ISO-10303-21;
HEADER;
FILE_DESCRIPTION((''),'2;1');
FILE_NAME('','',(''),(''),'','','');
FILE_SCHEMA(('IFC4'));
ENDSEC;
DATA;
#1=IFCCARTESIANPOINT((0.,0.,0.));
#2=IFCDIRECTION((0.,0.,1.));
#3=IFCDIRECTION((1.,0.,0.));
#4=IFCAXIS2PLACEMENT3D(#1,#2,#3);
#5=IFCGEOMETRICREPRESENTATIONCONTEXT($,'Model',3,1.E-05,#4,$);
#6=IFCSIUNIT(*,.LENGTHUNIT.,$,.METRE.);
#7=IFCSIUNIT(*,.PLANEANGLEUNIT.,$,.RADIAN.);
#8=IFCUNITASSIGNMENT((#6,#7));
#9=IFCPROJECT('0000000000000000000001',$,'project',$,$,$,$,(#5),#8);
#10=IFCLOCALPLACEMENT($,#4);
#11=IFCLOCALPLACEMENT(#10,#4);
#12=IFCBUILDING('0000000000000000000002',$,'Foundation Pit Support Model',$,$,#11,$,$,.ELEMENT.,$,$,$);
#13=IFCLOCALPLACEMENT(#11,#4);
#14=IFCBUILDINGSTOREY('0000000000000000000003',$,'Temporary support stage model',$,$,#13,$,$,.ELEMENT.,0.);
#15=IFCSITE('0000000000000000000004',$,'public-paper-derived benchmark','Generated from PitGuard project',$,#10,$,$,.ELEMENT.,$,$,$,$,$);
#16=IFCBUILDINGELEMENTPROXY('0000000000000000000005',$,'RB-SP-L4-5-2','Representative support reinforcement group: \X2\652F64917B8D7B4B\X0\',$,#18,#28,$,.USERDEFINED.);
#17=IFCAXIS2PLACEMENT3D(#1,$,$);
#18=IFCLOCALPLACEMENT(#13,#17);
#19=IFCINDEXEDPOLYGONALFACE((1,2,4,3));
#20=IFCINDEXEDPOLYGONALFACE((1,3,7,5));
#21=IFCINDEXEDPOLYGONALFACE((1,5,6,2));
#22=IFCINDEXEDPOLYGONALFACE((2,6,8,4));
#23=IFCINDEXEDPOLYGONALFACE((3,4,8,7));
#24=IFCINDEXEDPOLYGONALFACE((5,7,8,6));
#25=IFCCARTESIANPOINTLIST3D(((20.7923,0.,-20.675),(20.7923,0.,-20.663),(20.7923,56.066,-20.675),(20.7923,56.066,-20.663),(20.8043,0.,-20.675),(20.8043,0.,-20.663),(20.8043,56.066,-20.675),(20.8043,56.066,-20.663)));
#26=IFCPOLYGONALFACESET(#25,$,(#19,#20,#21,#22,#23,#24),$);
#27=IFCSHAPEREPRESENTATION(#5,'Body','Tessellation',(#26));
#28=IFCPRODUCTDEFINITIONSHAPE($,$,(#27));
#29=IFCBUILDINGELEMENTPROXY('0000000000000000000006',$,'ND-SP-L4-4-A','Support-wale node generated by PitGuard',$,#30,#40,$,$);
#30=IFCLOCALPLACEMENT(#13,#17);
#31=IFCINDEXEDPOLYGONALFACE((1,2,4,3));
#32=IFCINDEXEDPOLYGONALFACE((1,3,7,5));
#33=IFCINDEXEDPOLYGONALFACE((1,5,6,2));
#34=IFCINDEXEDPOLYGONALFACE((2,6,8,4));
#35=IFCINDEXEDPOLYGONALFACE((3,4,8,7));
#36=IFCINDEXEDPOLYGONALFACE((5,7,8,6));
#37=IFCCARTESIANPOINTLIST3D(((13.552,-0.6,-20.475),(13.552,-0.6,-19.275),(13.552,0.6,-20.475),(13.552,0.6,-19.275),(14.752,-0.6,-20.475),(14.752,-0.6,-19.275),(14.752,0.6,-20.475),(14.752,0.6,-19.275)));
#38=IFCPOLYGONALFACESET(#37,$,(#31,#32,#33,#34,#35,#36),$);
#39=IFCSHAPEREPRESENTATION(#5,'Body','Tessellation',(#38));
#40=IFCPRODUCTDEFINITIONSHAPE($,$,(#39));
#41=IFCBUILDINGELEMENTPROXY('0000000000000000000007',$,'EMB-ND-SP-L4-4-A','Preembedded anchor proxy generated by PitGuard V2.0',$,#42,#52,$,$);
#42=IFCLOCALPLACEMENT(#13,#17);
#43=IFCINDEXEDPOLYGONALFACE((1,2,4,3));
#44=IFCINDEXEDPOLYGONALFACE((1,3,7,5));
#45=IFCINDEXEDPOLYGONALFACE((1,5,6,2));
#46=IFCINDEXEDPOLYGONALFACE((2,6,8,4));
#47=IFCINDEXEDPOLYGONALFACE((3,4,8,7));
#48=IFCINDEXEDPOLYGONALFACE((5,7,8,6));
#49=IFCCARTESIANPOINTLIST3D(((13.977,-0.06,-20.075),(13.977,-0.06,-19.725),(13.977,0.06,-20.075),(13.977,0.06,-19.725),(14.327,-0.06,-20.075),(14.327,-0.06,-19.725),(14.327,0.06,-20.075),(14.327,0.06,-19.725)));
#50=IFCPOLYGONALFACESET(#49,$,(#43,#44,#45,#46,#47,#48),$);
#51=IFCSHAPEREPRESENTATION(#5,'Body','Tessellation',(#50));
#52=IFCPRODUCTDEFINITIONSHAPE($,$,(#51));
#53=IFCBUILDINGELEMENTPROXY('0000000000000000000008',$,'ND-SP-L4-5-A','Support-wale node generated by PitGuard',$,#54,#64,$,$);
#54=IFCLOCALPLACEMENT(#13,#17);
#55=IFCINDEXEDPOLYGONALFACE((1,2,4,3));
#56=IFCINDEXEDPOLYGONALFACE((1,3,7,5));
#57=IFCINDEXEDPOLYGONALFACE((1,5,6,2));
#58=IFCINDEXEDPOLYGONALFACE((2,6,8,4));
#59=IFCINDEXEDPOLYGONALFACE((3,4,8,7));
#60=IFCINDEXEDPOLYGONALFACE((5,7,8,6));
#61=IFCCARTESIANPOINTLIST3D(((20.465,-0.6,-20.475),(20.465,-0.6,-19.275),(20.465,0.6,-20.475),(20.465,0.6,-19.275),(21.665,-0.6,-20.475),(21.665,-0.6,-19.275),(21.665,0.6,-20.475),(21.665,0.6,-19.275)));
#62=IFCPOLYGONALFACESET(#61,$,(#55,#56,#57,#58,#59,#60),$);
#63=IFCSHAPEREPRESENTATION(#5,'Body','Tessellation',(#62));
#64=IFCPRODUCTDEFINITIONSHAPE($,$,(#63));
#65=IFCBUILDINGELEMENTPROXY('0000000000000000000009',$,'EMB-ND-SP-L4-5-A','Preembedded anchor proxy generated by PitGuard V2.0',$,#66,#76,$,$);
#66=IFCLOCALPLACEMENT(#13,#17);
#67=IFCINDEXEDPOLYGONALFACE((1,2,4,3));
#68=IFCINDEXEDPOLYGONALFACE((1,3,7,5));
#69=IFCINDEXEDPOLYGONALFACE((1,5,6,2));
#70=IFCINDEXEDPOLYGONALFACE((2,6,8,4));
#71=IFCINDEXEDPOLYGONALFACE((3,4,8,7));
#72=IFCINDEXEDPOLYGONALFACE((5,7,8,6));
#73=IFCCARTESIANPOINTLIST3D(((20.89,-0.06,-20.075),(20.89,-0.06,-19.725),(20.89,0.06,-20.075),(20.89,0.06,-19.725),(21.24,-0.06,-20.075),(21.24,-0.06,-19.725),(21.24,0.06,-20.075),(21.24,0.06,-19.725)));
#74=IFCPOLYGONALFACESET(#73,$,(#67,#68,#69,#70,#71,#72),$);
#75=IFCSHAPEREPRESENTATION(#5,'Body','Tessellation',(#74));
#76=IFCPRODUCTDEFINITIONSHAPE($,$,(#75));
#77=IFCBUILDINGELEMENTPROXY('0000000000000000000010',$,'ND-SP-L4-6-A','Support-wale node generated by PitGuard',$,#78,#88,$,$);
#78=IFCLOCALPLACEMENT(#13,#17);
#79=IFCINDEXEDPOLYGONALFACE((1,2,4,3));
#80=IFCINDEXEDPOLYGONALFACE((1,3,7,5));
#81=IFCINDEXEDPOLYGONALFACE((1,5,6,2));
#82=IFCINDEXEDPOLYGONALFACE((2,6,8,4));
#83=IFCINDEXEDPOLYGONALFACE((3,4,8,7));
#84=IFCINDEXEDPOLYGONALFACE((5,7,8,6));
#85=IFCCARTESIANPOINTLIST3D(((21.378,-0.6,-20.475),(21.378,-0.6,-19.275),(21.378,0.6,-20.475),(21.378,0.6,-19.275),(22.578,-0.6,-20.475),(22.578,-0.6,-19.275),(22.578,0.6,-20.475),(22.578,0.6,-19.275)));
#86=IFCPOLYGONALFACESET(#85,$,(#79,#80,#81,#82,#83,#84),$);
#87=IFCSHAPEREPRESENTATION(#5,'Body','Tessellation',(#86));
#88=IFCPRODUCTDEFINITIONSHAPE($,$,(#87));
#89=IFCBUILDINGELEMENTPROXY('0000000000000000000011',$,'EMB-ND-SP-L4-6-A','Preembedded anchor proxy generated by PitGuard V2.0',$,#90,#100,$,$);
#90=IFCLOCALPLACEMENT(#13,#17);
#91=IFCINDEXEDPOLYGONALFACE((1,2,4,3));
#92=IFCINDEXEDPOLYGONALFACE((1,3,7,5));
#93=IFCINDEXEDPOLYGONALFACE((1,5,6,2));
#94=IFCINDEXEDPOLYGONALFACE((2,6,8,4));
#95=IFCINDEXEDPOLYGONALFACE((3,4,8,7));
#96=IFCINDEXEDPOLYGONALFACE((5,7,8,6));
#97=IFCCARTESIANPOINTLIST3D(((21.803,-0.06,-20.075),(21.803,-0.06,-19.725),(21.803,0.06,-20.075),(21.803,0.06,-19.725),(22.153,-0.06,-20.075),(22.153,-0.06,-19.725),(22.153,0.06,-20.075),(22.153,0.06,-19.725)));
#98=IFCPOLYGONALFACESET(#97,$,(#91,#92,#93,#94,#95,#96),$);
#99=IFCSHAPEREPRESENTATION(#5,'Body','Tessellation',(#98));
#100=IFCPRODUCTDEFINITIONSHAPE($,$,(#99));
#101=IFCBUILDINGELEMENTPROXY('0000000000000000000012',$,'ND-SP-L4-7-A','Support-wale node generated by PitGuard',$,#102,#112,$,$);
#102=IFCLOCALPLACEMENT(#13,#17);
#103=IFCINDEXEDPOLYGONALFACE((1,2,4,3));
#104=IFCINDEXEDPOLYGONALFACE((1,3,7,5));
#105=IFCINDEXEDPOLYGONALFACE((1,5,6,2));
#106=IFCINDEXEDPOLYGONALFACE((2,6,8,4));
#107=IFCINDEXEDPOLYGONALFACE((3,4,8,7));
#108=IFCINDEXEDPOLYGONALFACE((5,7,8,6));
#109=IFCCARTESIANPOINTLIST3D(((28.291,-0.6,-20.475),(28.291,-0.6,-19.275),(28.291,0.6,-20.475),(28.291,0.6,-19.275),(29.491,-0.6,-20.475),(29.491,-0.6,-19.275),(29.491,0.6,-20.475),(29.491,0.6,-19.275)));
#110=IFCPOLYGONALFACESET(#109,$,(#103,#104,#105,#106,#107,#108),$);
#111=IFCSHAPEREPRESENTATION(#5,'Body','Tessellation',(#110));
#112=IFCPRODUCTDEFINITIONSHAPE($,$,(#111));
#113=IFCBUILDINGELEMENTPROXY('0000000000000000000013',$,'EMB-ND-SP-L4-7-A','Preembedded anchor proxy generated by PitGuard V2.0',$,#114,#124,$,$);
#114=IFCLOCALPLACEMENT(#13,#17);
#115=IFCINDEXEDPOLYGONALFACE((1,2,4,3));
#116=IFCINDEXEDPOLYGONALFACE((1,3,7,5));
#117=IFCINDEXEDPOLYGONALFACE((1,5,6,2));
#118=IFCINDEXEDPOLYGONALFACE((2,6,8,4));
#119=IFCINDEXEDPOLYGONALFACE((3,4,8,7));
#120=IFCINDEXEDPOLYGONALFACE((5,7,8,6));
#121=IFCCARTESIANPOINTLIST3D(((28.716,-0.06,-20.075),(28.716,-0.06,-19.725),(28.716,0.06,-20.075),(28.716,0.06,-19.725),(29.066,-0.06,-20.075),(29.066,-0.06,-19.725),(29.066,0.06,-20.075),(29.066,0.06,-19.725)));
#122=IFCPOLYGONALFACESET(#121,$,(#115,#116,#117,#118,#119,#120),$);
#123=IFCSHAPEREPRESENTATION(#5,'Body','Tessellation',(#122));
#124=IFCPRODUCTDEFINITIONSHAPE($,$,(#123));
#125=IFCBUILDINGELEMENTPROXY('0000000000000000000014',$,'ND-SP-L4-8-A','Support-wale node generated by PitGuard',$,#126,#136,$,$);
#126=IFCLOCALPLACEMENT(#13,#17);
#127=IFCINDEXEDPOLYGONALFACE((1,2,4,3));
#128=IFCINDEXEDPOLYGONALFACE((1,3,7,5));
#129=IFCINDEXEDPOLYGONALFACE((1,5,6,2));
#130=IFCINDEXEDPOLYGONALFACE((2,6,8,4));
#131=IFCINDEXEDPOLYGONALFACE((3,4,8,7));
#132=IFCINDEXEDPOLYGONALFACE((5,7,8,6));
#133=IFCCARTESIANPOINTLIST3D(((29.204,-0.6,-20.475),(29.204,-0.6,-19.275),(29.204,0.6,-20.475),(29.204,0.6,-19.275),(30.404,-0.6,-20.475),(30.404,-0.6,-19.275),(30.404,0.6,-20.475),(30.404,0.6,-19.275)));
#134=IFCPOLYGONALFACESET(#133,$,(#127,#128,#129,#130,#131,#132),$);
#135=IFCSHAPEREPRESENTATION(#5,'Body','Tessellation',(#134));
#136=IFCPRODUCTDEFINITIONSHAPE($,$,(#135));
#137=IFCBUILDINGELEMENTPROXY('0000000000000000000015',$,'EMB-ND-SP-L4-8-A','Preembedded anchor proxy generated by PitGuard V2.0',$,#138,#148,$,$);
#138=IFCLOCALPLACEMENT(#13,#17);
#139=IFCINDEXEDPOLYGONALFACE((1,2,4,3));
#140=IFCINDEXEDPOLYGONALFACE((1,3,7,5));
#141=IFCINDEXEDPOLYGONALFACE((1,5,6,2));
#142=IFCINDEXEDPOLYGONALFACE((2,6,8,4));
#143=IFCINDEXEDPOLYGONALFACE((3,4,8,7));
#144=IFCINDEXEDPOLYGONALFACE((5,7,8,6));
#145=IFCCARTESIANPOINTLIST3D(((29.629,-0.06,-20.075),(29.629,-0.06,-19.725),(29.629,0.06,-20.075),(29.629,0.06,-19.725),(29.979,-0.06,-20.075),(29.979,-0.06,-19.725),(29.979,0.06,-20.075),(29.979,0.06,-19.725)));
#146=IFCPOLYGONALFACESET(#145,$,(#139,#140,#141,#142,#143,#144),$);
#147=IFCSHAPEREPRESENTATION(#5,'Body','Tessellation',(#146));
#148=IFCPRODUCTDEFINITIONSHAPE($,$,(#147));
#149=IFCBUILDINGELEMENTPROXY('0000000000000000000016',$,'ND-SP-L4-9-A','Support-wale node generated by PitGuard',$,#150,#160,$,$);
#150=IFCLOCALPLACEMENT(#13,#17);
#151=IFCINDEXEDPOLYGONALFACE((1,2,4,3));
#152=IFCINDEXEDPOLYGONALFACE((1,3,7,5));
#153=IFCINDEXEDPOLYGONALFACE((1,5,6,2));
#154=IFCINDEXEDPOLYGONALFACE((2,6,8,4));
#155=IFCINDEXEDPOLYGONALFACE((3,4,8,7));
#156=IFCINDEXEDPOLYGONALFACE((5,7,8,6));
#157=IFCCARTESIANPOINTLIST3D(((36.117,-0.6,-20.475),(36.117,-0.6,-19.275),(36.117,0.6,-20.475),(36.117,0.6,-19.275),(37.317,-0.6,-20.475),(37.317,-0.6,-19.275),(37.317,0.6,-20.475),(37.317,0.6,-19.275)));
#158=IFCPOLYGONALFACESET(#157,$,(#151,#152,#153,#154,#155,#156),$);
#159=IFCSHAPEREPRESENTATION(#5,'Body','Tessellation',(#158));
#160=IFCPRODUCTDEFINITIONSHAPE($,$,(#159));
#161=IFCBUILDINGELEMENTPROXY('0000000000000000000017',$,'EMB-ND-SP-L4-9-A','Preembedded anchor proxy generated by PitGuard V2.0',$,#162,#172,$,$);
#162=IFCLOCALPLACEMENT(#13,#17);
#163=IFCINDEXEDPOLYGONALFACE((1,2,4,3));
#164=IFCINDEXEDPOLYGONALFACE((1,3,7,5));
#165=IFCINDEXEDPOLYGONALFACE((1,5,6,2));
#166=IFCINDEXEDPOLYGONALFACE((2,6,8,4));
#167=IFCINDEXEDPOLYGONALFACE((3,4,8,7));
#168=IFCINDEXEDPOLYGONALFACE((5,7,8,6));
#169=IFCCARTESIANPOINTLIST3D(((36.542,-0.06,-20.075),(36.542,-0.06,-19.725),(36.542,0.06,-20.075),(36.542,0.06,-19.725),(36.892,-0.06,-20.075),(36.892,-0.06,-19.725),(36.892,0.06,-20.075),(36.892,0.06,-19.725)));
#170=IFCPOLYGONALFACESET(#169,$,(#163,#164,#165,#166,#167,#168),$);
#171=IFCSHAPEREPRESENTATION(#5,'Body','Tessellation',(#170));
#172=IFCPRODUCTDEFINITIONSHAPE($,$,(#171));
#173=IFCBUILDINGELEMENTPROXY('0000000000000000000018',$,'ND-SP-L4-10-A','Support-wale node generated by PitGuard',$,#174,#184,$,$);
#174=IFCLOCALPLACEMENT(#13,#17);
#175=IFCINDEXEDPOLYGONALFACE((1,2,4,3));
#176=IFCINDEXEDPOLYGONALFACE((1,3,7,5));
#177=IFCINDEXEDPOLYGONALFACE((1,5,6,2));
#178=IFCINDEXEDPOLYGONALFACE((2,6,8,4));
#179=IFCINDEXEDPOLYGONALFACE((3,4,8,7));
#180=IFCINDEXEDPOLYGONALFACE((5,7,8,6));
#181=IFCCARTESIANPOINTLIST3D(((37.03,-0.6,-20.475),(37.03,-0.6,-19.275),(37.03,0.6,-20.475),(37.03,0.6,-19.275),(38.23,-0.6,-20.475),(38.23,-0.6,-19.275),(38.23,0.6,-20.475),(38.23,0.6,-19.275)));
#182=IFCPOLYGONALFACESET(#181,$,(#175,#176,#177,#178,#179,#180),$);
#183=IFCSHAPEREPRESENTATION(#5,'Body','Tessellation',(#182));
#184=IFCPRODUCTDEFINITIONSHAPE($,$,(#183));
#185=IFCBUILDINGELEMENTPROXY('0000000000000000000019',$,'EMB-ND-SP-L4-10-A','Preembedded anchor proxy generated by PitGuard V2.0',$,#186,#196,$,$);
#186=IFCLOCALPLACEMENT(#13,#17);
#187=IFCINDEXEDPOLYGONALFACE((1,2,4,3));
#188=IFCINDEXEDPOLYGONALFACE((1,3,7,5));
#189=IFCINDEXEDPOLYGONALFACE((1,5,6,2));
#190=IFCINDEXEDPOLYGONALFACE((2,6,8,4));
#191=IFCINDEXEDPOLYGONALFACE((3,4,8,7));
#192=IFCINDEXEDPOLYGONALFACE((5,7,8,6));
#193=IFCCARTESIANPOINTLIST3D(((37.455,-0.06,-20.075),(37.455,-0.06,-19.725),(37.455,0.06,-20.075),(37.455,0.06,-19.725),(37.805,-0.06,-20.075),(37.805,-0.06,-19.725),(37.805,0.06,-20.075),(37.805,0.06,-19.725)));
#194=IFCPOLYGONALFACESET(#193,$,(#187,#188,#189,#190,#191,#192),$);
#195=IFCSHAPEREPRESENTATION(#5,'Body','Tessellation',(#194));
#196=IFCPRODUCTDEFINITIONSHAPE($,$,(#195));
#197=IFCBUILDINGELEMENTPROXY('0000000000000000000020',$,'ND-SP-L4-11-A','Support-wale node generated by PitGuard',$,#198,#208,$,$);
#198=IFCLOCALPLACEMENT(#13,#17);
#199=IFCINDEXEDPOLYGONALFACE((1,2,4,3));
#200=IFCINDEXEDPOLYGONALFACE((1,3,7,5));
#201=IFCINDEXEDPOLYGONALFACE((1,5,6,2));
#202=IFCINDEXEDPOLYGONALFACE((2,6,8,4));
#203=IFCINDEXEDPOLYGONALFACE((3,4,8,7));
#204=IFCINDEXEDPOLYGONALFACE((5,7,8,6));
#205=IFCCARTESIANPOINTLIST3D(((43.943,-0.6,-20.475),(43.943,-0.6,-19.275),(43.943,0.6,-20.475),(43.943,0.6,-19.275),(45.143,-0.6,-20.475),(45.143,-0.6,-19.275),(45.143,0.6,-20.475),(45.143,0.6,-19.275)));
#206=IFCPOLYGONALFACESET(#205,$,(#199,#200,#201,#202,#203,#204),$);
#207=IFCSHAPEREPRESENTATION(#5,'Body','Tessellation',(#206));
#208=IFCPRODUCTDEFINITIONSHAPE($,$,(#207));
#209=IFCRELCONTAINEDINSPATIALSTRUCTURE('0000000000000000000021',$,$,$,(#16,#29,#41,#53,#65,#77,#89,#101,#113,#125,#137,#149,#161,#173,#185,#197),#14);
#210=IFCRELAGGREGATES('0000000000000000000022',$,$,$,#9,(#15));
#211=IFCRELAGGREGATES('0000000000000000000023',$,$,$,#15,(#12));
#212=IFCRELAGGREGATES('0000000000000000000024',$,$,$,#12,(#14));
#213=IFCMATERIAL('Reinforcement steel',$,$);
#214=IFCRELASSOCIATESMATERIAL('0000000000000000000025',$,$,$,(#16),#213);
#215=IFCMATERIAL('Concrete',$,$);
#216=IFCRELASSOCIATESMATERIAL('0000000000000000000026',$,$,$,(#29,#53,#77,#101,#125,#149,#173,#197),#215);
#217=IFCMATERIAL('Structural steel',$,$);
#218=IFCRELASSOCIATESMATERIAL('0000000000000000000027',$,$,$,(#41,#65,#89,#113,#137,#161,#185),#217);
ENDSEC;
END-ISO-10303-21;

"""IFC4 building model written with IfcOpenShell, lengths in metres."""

from ifc_helpers import new_model, si_unit, frame, origin_with_axes, origin_2d, place, context, project, spatial, rectangle, extrude, material, element, save


model = new_model("IFC4")

# Units and contexts
model_context = context("Model", 3, precision=1e-05, world=origin_with_axes())
ifc_project = project(units=[si_unit("LENGTHUNIT", "METRE"), si_unit("PLANEANGLEUNIT", "RADIAN")], contexts=[model_context])

# Site, building, storey
site_placement = place(None, origin_with_axes())
site = spatial("IfcSite", under=ifc_project, at=site_placement, Name="public-paper-derived benchmark", Description="Generated from PitGuard project", CompositionType="ELEMENT")
building_placement = place(site_placement, origin_with_axes())
building = spatial("IfcBuilding", under=site, at=building_placement, Name="Foundation Pit Support Model", CompositionType="ELEMENT")
storey_placement = place(building_placement, origin_with_axes())
storey = spatial("IfcBuildingStorey", under=building, at=storey_placement, Name="Temporary support stage model", CompositionType="ELEMENT", Elevation=0.0)

# Shared definitions
ifc_material_1 = material(Name="Concrete")

# Shared definitions
ifc_material_2 = material(Name="Structural steel")

# Building element proxies
ifc_material_3 = material(Name="Reinforcement steel")
proxy_1_placement = place(storey_placement, frame((20.7983, 28.033, -20.675), z_axis=(0.0, 0.0, 1.0), x_axis=(0.0, 1.0, 0.0)))
element("IfcBuildingElementProxy", 1, at=proxy_1_placement, inside=storey, material=ifc_material_3, Name="RB-SP-L4-5-2", Description="Representative support reinforcement group: 支撑箍筋", PredefinedType="USERDEFINED", context=model_context, shape_type="SweptSolid", body=[
    extrude(rectangle(XDim=56.066, YDim=0.012, at=origin_2d()), origin_with_axes(), (0.0, 0.0, 1.0), 0.012),
])
proxy_2_placement = place(storey_placement, frame((14.152, 0.0, -20.475), z_axis=(0.0, 0.0, 1.0), x_axis=(1.0, 0.0, 0.0)))
element("IfcBuildingElementProxy", 2, at=proxy_2_placement, inside=storey, material=ifc_material_1, Name="ND-SP-L4-4-A", Description="Support-wale node generated by PitGuard", context=model_context, shape_type="SweptSolid", body=[
    extrude(rectangle(XDim=1.2, YDim=1.2, at=origin_2d()), origin_with_axes(), (0.0, 0.0, 1.0), 1.2),
])
proxy_3_placement = place(storey_placement, frame((14.152, 0.0, -20.075), z_axis=(0.0, 0.0, 1.0), x_axis=(1.0, 0.0, 0.0)))
element("IfcBuildingElementProxy", 3, at=proxy_3_placement, inside=storey, material=ifc_material_2, Name="EMB-ND-SP-L4-4-A", Description="Preembedded anchor proxy generated by PitGuard V2.0", context=model_context, shape_type="SweptSolid", body=[
    extrude(rectangle(XDim=0.35, YDim=0.12, at=origin_2d()), origin_with_axes(), (0.0, 0.0, 1.0), 0.35),
])
proxy_4_placement = place(storey_placement, frame((21.065, 0.0, -20.475), z_axis=(0.0, 0.0, 1.0), x_axis=(1.0, 0.0, 0.0)))
element("IfcBuildingElementProxy", 4, at=proxy_4_placement, inside=storey, material=ifc_material_1, Name="ND-SP-L4-5-A", Description="Support-wale node generated by PitGuard", context=model_context, shape_type="SweptSolid", body=[
    extrude(rectangle(XDim=1.2, YDim=1.2, at=origin_2d()), origin_with_axes(), (0.0, 0.0, 1.0), 1.2),
])
proxy_5_placement = place(storey_placement, frame((21.065, 0.0, -20.075), z_axis=(0.0, 0.0, 1.0), x_axis=(1.0, 0.0, 0.0)))
element("IfcBuildingElementProxy", 5, at=proxy_5_placement, inside=storey, material=ifc_material_2, Name="EMB-ND-SP-L4-5-A", Description="Preembedded anchor proxy generated by PitGuard V2.0", context=model_context, shape_type="SweptSolid", body=[
    extrude(rectangle(XDim=0.35, YDim=0.12, at=origin_2d()), origin_with_axes(), (0.0, 0.0, 1.0), 0.35),
])
proxy_6_placement = place(storey_placement, frame((21.978, 0.0, -20.475), z_axis=(0.0, 0.0, 1.0), x_axis=(1.0, 0.0, 0.0)))
element("IfcBuildingElementProxy", 6, at=proxy_6_placement, inside=storey, material=ifc_material_1, Name="ND-SP-L4-6-A", Description="Support-wale node generated by PitGuard", context=model_context, shape_type="SweptSolid", body=[
    extrude(rectangle(XDim=1.2, YDim=1.2, at=origin_2d()), origin_with_axes(), (0.0, 0.0, 1.0), 1.2),
])
proxy_7_placement = place(storey_placement, frame((21.978, 0.0, -20.075), z_axis=(0.0, 0.0, 1.0), x_axis=(1.0, 0.0, 0.0)))
element("IfcBuildingElementProxy", 7, at=proxy_7_placement, inside=storey, material=ifc_material_2, Name="EMB-ND-SP-L4-6-A", Description="Preembedded anchor proxy generated by PitGuard V2.0", context=model_context, shape_type="SweptSolid", body=[
    extrude(rectangle(XDim=0.35, YDim=0.12, at=origin_2d()), origin_with_axes(), (0.0, 0.0, 1.0), 0.35),
])
proxy_8_placement = place(storey_placement, frame((28.891, 0.0, -20.475), z_axis=(0.0, 0.0, 1.0), x_axis=(1.0, 0.0, 0.0)))
element("IfcBuildingElementProxy", 8, at=proxy_8_placement, inside=storey, material=ifc_material_1, Name="ND-SP-L4-7-A", Description="Support-wale node generated by PitGuard", context=model_context, shape_type="SweptSolid", body=[
    extrude(rectangle(XDim=1.2, YDim=1.2, at=origin_2d()), origin_with_axes(), (0.0, 0.0, 1.0), 1.2),
])
proxy_9_placement = place(storey_placement, frame((28.891, 0.0, -20.075), z_axis=(0.0, 0.0, 1.0), x_axis=(1.0, 0.0, 0.0)))
element("IfcBuildingElementProxy", 9, at=proxy_9_placement, inside=storey, material=ifc_material_2, Name="EMB-ND-SP-L4-7-A", Description="Preembedded anchor proxy generated by PitGuard V2.0", context=model_context, shape_type="SweptSolid", body=[
    extrude(rectangle(XDim=0.35, YDim=0.12, at=origin_2d()), origin_with_axes(), (0.0, 0.0, 1.0), 0.35),
])
proxy_10_placement = place(storey_placement, frame((29.804, 0.0, -20.475), z_axis=(0.0, 0.0, 1.0), x_axis=(1.0, 0.0, 0.0)))
element("IfcBuildingElementProxy", 10, at=proxy_10_placement, inside=storey, material=ifc_material_1, Name="ND-SP-L4-8-A", Description="Support-wale node generated by PitGuard", context=model_context, shape_type="SweptSolid", body=[
    extrude(rectangle(XDim=1.2, YDim=1.2, at=origin_2d()), origin_with_axes(), (0.0, 0.0, 1.0), 1.2),
])
proxy_11_placement = place(storey_placement, frame((29.804, 0.0, -20.075), z_axis=(0.0, 0.0, 1.0), x_axis=(1.0, 0.0, 0.0)))
element("IfcBuildingElementProxy", 11, at=proxy_11_placement, inside=storey, material=ifc_material_2, Name="EMB-ND-SP-L4-8-A", Description="Preembedded anchor proxy generated by PitGuard V2.0", context=model_context, shape_type="SweptSolid", body=[
    extrude(rectangle(XDim=0.35, YDim=0.12, at=origin_2d()), origin_with_axes(), (0.0, 0.0, 1.0), 0.35),
])
proxy_12_placement = place(storey_placement, frame((36.717, 0.0, -20.475), z_axis=(0.0, 0.0, 1.0), x_axis=(1.0, 0.0, 0.0)))
element("IfcBuildingElementProxy", 12, at=proxy_12_placement, inside=storey, material=ifc_material_1, Name="ND-SP-L4-9-A", Description="Support-wale node generated by PitGuard", context=model_context, shape_type="SweptSolid", body=[
    extrude(rectangle(XDim=1.2, YDim=1.2, at=origin_2d()), origin_with_axes(), (0.0, 0.0, 1.0), 1.2),
])
proxy_13_placement = place(storey_placement, frame((36.717, 0.0, -20.075), z_axis=(0.0, 0.0, 1.0), x_axis=(1.0, 0.0, 0.0)))
element("IfcBuildingElementProxy", 13, at=proxy_13_placement, inside=storey, material=ifc_material_2, Name="EMB-ND-SP-L4-9-A", Description="Preembedded anchor proxy generated by PitGuard V2.0", context=model_context, shape_type="SweptSolid", body=[
    extrude(rectangle(XDim=0.35, YDim=0.12, at=origin_2d()), origin_with_axes(), (0.0, 0.0, 1.0), 0.35),
])
proxy_14_placement = place(storey_placement, frame((37.63, 0.0, -20.475), z_axis=(0.0, 0.0, 1.0), x_axis=(1.0, 0.0, 0.0)))
element("IfcBuildingElementProxy", 14, at=proxy_14_placement, inside=storey, material=ifc_material_1, Name="ND-SP-L4-10-A", Description="Support-wale node generated by PitGuard", context=model_context, shape_type="SweptSolid", body=[
    extrude(rectangle(XDim=1.2, YDim=1.2, at=origin_2d()), origin_with_axes(), (0.0, 0.0, 1.0), 1.2),
])
proxy_15_placement = place(storey_placement, frame((37.63, 0.0, -20.075), z_axis=(0.0, 0.0, 1.0), x_axis=(1.0, 0.0, 0.0)))
element("IfcBuildingElementProxy", 15, at=proxy_15_placement, inside=storey, material=ifc_material_2, Name="EMB-ND-SP-L4-10-A", Description="Preembedded anchor proxy generated by PitGuard V2.0", context=model_context, shape_type="SweptSolid", body=[
    extrude(rectangle(XDim=0.35, YDim=0.12, at=origin_2d()), origin_with_axes(), (0.0, 0.0, 1.0), 0.35),
])
proxy_16_placement = place(storey_placement, frame((44.543, 0.0, -20.475), z_axis=(0.0, 0.0, 1.0), x_axis=(1.0, 0.0, 0.0)))
element("IfcBuildingElementProxy", 16, at=proxy_16_placement, inside=storey, material=ifc_material_1, Name="ND-SP-L4-11-A", Description="Support-wale node generated by PitGuard", context=model_context, shape_type="SweptSolid", body=[
    extrude(rectangle(XDim=1.2, YDim=1.2, at=origin_2d()), origin_with_axes(), (0.0, 0.0, 1.0), 1.2),
])

save(model, "model.ifc")
